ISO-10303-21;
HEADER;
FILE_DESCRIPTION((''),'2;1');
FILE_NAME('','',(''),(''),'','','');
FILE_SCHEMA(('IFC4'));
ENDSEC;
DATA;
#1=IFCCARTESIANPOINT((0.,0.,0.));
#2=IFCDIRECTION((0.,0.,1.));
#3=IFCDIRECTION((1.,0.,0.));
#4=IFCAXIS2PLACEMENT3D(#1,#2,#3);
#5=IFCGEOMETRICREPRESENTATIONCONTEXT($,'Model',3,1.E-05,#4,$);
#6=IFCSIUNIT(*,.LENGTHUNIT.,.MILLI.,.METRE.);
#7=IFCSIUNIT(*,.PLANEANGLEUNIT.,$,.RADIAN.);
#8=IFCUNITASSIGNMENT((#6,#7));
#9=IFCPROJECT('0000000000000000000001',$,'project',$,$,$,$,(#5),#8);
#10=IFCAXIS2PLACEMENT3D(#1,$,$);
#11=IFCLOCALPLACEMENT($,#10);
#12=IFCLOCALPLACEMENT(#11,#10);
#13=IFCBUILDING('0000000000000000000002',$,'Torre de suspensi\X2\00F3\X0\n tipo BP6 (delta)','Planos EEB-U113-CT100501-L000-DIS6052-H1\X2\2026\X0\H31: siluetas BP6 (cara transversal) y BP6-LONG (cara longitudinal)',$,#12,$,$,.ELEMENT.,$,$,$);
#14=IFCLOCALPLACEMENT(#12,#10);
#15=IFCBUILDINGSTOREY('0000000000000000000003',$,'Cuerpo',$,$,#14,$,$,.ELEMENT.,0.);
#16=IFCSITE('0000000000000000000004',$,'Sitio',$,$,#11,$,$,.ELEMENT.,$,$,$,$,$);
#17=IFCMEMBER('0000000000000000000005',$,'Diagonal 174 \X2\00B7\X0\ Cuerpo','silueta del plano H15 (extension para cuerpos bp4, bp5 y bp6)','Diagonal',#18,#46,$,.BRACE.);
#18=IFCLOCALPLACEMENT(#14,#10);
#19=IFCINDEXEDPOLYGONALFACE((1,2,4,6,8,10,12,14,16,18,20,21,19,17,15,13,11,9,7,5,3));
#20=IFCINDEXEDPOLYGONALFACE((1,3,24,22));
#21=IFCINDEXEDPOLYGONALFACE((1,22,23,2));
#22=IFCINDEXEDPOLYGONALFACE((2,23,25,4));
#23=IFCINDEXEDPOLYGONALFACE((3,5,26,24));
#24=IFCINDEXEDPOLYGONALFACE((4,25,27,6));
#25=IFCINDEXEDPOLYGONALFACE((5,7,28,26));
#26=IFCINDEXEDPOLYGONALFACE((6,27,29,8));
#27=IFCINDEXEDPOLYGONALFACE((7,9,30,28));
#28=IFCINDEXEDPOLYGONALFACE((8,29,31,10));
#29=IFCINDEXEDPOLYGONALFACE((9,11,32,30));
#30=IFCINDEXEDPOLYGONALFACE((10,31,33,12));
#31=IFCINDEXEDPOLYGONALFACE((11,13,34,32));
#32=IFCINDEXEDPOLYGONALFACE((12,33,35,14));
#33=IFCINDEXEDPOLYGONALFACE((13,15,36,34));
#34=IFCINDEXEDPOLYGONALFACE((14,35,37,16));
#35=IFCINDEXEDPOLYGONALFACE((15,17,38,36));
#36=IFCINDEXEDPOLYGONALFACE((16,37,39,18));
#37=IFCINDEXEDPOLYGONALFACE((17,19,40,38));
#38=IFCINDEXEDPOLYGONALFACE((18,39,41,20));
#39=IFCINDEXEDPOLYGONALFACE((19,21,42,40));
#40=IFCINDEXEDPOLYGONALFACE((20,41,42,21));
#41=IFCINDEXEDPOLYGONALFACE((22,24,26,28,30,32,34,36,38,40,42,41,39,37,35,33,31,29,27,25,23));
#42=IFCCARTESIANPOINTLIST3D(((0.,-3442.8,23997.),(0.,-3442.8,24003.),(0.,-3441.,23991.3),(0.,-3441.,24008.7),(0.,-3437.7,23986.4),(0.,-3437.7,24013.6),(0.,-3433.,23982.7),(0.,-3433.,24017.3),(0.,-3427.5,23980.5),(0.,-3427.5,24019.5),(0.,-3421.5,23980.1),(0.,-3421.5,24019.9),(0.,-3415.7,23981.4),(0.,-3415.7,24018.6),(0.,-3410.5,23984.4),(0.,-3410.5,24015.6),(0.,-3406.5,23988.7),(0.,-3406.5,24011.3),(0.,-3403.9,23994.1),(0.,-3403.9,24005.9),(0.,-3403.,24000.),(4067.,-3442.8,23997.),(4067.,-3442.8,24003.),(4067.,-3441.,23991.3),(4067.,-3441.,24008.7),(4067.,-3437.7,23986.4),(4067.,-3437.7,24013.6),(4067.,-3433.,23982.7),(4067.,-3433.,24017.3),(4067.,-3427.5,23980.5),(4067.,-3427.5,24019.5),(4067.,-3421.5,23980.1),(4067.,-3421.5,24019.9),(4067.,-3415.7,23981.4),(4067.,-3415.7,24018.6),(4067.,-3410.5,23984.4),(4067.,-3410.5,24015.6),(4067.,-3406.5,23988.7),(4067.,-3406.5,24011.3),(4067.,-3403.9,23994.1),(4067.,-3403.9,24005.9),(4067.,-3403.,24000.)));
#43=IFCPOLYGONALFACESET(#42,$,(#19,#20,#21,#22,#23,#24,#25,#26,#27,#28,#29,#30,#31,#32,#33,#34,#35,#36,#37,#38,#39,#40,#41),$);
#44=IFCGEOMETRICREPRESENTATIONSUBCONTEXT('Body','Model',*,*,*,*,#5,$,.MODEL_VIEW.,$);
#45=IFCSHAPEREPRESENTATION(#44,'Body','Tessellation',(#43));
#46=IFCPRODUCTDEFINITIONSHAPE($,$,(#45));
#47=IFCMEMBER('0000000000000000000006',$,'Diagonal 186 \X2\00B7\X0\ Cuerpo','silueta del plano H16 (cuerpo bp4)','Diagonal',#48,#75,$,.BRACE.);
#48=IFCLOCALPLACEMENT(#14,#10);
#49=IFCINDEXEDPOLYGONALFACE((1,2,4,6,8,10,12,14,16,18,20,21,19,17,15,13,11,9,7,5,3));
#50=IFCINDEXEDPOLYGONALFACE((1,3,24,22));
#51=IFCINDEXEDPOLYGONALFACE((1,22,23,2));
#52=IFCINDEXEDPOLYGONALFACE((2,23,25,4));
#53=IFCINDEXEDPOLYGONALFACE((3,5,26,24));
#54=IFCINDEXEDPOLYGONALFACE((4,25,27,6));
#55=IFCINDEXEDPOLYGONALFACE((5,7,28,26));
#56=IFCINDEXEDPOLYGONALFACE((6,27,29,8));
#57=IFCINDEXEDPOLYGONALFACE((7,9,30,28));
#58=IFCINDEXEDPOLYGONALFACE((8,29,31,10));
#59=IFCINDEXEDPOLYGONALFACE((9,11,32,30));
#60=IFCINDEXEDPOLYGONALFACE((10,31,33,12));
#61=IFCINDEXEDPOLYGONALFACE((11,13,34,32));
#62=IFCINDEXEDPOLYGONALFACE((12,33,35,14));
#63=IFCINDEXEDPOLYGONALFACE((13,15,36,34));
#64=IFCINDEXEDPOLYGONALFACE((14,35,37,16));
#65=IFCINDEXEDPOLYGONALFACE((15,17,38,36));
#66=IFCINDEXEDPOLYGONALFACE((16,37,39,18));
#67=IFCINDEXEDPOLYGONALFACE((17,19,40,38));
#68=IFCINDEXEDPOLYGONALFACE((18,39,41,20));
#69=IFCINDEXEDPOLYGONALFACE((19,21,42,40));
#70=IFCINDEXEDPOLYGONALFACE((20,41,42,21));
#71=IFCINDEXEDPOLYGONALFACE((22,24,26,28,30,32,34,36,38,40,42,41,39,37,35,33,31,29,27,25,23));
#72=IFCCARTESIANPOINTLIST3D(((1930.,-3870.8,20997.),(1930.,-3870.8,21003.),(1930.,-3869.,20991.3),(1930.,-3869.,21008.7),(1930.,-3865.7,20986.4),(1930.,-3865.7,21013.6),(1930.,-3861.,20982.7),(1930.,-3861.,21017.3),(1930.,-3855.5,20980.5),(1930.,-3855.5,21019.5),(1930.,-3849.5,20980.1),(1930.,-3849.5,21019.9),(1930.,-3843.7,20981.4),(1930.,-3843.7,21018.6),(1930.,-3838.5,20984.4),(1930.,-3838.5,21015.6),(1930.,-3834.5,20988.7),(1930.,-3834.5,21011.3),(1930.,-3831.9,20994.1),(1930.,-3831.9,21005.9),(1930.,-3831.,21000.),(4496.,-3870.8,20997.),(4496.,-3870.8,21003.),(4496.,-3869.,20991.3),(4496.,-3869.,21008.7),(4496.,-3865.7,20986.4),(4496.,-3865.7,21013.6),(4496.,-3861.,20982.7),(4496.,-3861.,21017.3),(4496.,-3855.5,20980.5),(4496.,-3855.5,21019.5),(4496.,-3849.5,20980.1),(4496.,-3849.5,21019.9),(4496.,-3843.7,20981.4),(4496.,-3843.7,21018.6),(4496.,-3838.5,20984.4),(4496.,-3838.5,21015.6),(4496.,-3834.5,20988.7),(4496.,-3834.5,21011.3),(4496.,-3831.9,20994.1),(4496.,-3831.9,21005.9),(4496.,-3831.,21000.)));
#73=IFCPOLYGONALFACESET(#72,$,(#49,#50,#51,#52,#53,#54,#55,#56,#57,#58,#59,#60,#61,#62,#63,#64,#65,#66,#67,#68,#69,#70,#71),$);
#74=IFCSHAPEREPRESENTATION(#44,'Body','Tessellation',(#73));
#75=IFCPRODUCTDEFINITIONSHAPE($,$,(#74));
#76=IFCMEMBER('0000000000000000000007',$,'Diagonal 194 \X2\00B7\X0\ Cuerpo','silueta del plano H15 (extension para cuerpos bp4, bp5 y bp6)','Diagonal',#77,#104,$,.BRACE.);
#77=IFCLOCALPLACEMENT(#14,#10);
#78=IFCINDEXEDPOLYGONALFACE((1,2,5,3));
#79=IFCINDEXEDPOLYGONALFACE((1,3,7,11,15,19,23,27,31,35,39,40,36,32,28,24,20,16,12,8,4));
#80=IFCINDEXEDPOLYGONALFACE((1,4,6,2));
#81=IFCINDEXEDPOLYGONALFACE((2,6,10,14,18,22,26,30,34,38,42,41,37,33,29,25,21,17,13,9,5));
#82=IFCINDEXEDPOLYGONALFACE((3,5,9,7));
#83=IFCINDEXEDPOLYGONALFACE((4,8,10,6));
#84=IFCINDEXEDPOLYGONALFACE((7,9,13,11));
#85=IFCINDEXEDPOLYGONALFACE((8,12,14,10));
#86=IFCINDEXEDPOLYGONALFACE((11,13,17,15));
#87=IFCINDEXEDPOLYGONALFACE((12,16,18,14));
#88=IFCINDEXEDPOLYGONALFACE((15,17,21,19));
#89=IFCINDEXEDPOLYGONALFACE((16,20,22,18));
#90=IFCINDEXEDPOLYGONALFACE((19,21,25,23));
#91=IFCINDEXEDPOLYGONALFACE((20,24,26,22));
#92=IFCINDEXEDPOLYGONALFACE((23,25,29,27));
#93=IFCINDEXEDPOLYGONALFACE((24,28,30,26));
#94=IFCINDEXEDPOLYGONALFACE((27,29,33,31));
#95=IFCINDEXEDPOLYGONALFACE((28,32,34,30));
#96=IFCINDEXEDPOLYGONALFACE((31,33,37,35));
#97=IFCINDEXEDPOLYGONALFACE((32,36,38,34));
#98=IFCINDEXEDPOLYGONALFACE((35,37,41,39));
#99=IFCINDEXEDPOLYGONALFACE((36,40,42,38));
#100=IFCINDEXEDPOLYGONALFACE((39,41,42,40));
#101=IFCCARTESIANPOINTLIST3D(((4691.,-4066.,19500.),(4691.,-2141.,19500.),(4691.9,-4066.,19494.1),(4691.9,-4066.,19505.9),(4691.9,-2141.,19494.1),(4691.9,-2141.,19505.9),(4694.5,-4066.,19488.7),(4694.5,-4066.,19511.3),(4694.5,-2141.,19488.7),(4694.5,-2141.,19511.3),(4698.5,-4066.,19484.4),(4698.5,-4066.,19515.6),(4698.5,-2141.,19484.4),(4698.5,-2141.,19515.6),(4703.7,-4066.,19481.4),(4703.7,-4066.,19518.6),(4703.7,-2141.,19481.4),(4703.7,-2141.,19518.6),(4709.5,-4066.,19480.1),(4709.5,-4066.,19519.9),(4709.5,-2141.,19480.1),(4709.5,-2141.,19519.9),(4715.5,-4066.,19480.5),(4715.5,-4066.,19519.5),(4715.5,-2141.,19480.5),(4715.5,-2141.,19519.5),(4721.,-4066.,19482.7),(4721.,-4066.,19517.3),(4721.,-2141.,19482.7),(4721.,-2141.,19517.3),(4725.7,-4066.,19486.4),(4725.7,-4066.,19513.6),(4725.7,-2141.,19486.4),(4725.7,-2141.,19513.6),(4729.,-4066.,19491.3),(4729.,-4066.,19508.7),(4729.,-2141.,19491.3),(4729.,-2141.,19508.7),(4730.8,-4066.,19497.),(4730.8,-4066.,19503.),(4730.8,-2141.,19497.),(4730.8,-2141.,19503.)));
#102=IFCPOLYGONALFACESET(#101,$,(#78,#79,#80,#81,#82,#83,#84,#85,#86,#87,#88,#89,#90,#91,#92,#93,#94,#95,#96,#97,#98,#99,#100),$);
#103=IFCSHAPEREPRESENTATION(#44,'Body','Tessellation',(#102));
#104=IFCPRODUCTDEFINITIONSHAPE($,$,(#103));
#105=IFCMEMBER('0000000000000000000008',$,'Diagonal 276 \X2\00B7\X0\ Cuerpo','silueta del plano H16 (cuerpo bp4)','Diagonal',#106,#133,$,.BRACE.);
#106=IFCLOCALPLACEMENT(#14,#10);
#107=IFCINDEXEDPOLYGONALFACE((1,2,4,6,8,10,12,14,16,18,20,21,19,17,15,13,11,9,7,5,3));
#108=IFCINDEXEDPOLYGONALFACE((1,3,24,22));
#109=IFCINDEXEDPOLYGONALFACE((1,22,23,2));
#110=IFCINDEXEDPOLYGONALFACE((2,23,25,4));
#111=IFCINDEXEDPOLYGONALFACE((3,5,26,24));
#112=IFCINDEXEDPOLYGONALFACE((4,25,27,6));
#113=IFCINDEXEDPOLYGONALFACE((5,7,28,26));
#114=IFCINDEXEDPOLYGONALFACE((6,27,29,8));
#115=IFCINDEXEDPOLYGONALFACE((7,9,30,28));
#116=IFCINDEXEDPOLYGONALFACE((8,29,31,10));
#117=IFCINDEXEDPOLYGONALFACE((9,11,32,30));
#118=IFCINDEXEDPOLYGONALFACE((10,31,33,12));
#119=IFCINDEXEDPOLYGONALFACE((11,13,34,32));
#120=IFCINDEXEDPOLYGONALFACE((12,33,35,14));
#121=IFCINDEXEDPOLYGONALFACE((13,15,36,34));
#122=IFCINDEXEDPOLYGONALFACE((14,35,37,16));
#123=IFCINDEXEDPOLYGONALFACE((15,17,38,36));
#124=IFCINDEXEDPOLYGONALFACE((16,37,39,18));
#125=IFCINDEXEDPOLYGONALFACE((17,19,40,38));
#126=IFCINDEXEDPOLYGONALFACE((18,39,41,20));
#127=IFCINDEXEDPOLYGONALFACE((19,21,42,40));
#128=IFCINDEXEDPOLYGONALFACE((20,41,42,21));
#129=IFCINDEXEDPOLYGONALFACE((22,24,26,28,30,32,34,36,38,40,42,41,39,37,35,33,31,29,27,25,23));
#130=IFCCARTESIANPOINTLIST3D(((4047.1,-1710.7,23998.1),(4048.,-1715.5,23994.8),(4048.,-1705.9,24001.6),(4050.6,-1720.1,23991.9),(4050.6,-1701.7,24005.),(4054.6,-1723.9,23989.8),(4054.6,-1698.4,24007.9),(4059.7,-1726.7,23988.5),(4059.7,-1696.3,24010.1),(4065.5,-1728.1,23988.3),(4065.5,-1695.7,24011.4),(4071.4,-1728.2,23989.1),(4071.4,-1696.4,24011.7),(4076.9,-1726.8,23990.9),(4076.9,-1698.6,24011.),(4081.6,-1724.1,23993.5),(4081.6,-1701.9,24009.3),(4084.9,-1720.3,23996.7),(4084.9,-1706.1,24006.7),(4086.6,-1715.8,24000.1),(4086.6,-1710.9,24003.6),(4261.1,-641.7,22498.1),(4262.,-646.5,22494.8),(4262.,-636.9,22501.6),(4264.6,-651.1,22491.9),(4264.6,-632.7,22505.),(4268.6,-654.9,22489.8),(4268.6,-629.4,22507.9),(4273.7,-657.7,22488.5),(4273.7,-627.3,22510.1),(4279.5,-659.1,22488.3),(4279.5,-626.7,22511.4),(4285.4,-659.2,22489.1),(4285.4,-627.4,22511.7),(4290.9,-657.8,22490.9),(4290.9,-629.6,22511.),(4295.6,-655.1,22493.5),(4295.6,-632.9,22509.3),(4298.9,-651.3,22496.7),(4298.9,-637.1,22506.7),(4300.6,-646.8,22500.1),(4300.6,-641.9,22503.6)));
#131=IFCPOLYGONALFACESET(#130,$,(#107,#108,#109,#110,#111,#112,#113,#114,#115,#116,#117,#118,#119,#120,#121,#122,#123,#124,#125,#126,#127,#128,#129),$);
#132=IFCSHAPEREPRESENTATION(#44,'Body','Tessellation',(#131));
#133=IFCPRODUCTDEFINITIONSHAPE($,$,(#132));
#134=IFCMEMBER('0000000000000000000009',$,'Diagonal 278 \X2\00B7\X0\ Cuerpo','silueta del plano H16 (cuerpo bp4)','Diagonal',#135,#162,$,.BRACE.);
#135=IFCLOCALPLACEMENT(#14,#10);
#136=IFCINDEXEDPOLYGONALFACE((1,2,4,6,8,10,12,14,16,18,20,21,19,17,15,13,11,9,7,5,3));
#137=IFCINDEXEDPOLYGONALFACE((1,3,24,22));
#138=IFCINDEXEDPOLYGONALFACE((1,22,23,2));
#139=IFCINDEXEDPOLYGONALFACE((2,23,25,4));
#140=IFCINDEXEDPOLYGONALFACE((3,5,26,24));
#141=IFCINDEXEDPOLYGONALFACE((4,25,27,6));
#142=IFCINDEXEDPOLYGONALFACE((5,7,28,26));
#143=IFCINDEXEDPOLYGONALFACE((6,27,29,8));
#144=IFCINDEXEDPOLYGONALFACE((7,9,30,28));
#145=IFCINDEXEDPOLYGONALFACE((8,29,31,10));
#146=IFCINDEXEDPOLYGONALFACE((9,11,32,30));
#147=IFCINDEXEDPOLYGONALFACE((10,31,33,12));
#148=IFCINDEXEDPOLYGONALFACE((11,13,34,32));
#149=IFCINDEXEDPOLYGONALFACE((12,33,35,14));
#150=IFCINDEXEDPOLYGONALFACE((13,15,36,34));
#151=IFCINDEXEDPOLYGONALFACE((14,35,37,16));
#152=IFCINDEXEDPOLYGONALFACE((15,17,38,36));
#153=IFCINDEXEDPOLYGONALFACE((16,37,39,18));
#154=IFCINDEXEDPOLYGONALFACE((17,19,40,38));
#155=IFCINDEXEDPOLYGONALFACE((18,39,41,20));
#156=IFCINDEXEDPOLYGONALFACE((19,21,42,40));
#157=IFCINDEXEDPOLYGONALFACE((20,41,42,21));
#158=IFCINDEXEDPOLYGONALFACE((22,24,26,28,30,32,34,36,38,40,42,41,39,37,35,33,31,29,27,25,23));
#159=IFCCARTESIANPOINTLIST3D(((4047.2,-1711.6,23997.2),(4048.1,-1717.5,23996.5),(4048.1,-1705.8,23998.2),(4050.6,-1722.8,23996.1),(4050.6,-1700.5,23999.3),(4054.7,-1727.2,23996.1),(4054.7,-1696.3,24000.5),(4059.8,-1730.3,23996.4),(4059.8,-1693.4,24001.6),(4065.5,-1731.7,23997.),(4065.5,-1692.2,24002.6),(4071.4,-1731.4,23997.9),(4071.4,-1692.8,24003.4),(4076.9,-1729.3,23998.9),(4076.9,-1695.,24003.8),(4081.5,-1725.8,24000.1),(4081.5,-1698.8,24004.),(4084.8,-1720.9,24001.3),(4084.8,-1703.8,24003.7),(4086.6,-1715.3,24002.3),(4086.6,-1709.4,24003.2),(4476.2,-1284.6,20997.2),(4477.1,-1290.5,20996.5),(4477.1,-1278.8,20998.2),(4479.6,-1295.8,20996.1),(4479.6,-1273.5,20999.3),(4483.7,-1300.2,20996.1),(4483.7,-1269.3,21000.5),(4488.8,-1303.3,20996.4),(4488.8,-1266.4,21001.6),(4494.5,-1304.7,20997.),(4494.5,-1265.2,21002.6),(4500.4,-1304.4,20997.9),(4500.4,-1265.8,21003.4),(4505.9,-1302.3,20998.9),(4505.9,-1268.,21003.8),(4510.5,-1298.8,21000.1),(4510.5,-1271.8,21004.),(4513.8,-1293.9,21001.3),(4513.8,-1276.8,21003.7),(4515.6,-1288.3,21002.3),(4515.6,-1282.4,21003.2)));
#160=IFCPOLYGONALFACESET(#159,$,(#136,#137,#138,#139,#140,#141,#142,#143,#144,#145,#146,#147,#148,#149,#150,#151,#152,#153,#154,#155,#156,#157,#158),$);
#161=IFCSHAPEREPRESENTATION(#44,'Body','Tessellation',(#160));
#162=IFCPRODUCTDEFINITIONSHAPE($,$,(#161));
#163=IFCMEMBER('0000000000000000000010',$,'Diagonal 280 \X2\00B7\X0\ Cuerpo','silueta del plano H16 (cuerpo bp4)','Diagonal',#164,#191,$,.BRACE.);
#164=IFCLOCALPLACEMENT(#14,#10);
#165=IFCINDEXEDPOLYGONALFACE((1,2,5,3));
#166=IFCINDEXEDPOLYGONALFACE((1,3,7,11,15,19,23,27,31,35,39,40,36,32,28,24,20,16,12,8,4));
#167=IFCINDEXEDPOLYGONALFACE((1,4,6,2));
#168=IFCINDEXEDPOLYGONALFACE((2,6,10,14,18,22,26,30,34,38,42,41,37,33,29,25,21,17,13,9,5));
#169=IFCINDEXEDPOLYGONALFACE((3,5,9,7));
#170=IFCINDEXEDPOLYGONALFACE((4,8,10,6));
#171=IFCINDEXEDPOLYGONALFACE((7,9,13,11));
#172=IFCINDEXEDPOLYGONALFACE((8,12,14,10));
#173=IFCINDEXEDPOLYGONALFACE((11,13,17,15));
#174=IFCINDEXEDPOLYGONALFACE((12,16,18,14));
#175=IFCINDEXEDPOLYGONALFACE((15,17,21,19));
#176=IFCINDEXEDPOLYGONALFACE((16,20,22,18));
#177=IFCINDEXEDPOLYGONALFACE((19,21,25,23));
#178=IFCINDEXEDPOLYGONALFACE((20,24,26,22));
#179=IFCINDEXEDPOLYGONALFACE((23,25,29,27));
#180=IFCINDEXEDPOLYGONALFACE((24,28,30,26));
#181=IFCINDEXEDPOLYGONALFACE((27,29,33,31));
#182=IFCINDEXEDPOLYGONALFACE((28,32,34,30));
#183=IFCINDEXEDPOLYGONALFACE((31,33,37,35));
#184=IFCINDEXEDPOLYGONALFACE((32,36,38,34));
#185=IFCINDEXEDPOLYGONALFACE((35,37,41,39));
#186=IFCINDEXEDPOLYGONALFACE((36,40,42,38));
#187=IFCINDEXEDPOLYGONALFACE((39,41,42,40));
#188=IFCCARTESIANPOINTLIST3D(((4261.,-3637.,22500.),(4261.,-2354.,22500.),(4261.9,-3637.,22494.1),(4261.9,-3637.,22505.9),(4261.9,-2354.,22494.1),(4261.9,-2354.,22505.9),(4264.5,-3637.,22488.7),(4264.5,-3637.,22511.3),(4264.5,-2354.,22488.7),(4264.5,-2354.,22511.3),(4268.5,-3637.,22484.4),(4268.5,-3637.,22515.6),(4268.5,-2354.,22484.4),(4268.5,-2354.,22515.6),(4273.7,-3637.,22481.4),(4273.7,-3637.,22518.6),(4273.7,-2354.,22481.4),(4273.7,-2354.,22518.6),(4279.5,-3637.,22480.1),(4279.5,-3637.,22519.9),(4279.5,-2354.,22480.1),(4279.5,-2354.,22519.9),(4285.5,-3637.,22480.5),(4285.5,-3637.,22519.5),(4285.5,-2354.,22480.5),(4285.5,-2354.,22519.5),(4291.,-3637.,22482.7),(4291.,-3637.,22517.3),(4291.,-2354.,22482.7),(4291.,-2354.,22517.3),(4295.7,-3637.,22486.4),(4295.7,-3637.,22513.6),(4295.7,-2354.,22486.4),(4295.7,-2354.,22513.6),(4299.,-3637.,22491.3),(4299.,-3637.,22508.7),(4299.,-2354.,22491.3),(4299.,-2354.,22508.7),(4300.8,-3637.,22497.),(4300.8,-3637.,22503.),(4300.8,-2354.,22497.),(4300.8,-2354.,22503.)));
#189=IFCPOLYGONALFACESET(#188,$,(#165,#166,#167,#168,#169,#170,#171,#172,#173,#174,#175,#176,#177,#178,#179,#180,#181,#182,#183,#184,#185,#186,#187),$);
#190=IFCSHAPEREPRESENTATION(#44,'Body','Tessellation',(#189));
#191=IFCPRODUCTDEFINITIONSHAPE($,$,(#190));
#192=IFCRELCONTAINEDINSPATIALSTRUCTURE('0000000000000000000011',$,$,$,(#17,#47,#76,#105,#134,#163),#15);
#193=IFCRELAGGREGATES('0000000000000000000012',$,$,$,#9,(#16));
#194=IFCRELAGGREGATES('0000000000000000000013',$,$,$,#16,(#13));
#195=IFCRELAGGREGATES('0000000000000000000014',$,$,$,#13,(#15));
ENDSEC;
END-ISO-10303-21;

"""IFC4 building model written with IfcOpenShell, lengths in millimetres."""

from ifc_helpers import new_model, si_unit, frame, origin, origin_with_axes, place, context, subcontext, project, spatial, circle, extrude, element, save


model = new_model("IFC4")

# Units and contexts
model_context = context("Model", 3, precision=1e-05, world=origin_with_axes())
body_context = subcontext(model_context, "Body", "Model", "MODEL_VIEW")
ifc_project = project(units=[si_unit("LENGTHUNIT", "METRE", prefix="MILLI"), si_unit("PLANEANGLEUNIT", "RADIAN")], contexts=[model_context])

# Site, building, storey
site_placement = place(None, origin())
site = spatial("IfcSite", under=ifc_project, at=site_placement, Name="Sitio", CompositionType="ELEMENT")
building_placement = place(site_placement, origin())
building = spatial("IfcBuilding", under=site, at=building_placement, Name="Torre de suspensión tipo BP6 (delta)", Description="Planos EEB-U113-CT100501-L000-DIS6052-H1…H31: siluetas BP6 (cara transversal) y BP6-LONG (cara longitudinal)", CompositionType="ELEMENT")
storey_placement = place(building_placement, origin())
storey = spatial("IfcBuildingStorey", under=building, at=storey_placement, Name="Cuerpo", CompositionType="ELEMENT", Elevation=0.0)

# Members
member_1_placement = place(storey_placement, frame((4067.0, -3423.0, 24000.0), z_axis=(-1.0, 0.0, 0.0), x_axis=(0.0, 1.0, 0.0)))
element("IfcMember", 1, at=member_1_placement, inside=storey, Name="Diagonal 174 · Cuerpo", Description="silueta del plano H15 (extension para cuerpos bp4, bp5 y bp6)", ObjectType="Diagonal", PredefinedType="BRACE", context=body_context, shape_type="SweptSolid", body=[
    extrude(circle(Radius=20.0), None, (0.0, 0.0, 1.0), 4067.0),
])
member_2_placement = place(storey_placement, frame((4496.0, -3851.0, 21000.0), z_axis=(-1.0, 0.0, 0.0), x_axis=(0.0, 1.0, 0.0)))
element("IfcMember", 2, at=member_2_placement, inside=storey, Name="Diagonal 186 · Cuerpo", Description="silueta del plano H16 (cuerpo bp4)", ObjectType="Diagonal", PredefinedType="BRACE", context=body_context, shape_type="SweptSolid", body=[
    extrude(circle(Radius=20.0), None, (0.0, 0.0, 1.0), 2566.0),
])
member_3_placement = place(storey_placement, frame((4711.0, -2141.0, 19500.0), z_axis=(0.0, -1.0, 0.0), x_axis=(-1.0, 0.0, 0.0)))
element("IfcMember", 3, at=member_3_placement, inside=storey, Name="Diagonal 194 · Cuerpo", Description="silueta del plano H15 (extension para cuerpos bp4, bp5 y bp6)", ObjectType="Diagonal", PredefinedType="BRACE", context=body_context, shape_type="SweptSolid", body=[
    extrude(circle(Radius=20.0), None, (0.0, 0.0, 1.0), 1925.0),
])
member_4_placement = place(storey_placement, frame((4281.0, -643.0, 22500.0), z_axis=(-0.115405, -0.576487, 0.808915), x_axis=(-0.993318, 0.066977, -0.093981)))
element("IfcMember", 4, at=member_4_placement, inside=storey, Name="Diagonal 276 · Cuerpo", Description="silueta del plano H16 (cuerpo bp4)", ObjectType="Diagonal", PredefinedType="BRACE", context=body_context, shape_type="SweptSolid", body=[
    extrude(circle(Radius=20.0), None, (0.0, 0.0, 1.0), 1854.3),
])
member_5_placement = place(storey_placement, frame((4067.0, -1712.0, 24000.0), z_axis=(0.140175, 0.139522, -0.980247), x_axis=(-0.990127, 0.019753, -0.138777)))
element("IfcMember", 5, at=member_5_placement, inside=storey, Name="Diagonal 278 · Cuerpo", Description="silueta del plano H16 (cuerpo bp4)", ObjectType="Diagonal", PredefinedType="BRACE", context=body_context, shape_type="SweptSolid", body=[
    extrude(circle(Radius=20.0), None, (0.0, 0.0, 1.0), 3060.5),
])
member_6_placement = place(storey_placement, frame((4281.0, -2354.0, 22500.0), z_axis=(0.0, -1.0, 0.0), x_axis=(-1.0, 0.0, 0.0)))
element("IfcMember", 6, at=member_6_placement, inside=storey, Name="Diagonal 280 · Cuerpo", Description="silueta del plano H16 (cuerpo bp4)", ObjectType="Diagonal", PredefinedType="BRACE", context=body_context, shape_type="SweptSolid", body=[
    extrude(circle(Radius=20.0), None, (0.0, 0.0, 1.0), 1283.0),
])

save(model, "model.ifc")
